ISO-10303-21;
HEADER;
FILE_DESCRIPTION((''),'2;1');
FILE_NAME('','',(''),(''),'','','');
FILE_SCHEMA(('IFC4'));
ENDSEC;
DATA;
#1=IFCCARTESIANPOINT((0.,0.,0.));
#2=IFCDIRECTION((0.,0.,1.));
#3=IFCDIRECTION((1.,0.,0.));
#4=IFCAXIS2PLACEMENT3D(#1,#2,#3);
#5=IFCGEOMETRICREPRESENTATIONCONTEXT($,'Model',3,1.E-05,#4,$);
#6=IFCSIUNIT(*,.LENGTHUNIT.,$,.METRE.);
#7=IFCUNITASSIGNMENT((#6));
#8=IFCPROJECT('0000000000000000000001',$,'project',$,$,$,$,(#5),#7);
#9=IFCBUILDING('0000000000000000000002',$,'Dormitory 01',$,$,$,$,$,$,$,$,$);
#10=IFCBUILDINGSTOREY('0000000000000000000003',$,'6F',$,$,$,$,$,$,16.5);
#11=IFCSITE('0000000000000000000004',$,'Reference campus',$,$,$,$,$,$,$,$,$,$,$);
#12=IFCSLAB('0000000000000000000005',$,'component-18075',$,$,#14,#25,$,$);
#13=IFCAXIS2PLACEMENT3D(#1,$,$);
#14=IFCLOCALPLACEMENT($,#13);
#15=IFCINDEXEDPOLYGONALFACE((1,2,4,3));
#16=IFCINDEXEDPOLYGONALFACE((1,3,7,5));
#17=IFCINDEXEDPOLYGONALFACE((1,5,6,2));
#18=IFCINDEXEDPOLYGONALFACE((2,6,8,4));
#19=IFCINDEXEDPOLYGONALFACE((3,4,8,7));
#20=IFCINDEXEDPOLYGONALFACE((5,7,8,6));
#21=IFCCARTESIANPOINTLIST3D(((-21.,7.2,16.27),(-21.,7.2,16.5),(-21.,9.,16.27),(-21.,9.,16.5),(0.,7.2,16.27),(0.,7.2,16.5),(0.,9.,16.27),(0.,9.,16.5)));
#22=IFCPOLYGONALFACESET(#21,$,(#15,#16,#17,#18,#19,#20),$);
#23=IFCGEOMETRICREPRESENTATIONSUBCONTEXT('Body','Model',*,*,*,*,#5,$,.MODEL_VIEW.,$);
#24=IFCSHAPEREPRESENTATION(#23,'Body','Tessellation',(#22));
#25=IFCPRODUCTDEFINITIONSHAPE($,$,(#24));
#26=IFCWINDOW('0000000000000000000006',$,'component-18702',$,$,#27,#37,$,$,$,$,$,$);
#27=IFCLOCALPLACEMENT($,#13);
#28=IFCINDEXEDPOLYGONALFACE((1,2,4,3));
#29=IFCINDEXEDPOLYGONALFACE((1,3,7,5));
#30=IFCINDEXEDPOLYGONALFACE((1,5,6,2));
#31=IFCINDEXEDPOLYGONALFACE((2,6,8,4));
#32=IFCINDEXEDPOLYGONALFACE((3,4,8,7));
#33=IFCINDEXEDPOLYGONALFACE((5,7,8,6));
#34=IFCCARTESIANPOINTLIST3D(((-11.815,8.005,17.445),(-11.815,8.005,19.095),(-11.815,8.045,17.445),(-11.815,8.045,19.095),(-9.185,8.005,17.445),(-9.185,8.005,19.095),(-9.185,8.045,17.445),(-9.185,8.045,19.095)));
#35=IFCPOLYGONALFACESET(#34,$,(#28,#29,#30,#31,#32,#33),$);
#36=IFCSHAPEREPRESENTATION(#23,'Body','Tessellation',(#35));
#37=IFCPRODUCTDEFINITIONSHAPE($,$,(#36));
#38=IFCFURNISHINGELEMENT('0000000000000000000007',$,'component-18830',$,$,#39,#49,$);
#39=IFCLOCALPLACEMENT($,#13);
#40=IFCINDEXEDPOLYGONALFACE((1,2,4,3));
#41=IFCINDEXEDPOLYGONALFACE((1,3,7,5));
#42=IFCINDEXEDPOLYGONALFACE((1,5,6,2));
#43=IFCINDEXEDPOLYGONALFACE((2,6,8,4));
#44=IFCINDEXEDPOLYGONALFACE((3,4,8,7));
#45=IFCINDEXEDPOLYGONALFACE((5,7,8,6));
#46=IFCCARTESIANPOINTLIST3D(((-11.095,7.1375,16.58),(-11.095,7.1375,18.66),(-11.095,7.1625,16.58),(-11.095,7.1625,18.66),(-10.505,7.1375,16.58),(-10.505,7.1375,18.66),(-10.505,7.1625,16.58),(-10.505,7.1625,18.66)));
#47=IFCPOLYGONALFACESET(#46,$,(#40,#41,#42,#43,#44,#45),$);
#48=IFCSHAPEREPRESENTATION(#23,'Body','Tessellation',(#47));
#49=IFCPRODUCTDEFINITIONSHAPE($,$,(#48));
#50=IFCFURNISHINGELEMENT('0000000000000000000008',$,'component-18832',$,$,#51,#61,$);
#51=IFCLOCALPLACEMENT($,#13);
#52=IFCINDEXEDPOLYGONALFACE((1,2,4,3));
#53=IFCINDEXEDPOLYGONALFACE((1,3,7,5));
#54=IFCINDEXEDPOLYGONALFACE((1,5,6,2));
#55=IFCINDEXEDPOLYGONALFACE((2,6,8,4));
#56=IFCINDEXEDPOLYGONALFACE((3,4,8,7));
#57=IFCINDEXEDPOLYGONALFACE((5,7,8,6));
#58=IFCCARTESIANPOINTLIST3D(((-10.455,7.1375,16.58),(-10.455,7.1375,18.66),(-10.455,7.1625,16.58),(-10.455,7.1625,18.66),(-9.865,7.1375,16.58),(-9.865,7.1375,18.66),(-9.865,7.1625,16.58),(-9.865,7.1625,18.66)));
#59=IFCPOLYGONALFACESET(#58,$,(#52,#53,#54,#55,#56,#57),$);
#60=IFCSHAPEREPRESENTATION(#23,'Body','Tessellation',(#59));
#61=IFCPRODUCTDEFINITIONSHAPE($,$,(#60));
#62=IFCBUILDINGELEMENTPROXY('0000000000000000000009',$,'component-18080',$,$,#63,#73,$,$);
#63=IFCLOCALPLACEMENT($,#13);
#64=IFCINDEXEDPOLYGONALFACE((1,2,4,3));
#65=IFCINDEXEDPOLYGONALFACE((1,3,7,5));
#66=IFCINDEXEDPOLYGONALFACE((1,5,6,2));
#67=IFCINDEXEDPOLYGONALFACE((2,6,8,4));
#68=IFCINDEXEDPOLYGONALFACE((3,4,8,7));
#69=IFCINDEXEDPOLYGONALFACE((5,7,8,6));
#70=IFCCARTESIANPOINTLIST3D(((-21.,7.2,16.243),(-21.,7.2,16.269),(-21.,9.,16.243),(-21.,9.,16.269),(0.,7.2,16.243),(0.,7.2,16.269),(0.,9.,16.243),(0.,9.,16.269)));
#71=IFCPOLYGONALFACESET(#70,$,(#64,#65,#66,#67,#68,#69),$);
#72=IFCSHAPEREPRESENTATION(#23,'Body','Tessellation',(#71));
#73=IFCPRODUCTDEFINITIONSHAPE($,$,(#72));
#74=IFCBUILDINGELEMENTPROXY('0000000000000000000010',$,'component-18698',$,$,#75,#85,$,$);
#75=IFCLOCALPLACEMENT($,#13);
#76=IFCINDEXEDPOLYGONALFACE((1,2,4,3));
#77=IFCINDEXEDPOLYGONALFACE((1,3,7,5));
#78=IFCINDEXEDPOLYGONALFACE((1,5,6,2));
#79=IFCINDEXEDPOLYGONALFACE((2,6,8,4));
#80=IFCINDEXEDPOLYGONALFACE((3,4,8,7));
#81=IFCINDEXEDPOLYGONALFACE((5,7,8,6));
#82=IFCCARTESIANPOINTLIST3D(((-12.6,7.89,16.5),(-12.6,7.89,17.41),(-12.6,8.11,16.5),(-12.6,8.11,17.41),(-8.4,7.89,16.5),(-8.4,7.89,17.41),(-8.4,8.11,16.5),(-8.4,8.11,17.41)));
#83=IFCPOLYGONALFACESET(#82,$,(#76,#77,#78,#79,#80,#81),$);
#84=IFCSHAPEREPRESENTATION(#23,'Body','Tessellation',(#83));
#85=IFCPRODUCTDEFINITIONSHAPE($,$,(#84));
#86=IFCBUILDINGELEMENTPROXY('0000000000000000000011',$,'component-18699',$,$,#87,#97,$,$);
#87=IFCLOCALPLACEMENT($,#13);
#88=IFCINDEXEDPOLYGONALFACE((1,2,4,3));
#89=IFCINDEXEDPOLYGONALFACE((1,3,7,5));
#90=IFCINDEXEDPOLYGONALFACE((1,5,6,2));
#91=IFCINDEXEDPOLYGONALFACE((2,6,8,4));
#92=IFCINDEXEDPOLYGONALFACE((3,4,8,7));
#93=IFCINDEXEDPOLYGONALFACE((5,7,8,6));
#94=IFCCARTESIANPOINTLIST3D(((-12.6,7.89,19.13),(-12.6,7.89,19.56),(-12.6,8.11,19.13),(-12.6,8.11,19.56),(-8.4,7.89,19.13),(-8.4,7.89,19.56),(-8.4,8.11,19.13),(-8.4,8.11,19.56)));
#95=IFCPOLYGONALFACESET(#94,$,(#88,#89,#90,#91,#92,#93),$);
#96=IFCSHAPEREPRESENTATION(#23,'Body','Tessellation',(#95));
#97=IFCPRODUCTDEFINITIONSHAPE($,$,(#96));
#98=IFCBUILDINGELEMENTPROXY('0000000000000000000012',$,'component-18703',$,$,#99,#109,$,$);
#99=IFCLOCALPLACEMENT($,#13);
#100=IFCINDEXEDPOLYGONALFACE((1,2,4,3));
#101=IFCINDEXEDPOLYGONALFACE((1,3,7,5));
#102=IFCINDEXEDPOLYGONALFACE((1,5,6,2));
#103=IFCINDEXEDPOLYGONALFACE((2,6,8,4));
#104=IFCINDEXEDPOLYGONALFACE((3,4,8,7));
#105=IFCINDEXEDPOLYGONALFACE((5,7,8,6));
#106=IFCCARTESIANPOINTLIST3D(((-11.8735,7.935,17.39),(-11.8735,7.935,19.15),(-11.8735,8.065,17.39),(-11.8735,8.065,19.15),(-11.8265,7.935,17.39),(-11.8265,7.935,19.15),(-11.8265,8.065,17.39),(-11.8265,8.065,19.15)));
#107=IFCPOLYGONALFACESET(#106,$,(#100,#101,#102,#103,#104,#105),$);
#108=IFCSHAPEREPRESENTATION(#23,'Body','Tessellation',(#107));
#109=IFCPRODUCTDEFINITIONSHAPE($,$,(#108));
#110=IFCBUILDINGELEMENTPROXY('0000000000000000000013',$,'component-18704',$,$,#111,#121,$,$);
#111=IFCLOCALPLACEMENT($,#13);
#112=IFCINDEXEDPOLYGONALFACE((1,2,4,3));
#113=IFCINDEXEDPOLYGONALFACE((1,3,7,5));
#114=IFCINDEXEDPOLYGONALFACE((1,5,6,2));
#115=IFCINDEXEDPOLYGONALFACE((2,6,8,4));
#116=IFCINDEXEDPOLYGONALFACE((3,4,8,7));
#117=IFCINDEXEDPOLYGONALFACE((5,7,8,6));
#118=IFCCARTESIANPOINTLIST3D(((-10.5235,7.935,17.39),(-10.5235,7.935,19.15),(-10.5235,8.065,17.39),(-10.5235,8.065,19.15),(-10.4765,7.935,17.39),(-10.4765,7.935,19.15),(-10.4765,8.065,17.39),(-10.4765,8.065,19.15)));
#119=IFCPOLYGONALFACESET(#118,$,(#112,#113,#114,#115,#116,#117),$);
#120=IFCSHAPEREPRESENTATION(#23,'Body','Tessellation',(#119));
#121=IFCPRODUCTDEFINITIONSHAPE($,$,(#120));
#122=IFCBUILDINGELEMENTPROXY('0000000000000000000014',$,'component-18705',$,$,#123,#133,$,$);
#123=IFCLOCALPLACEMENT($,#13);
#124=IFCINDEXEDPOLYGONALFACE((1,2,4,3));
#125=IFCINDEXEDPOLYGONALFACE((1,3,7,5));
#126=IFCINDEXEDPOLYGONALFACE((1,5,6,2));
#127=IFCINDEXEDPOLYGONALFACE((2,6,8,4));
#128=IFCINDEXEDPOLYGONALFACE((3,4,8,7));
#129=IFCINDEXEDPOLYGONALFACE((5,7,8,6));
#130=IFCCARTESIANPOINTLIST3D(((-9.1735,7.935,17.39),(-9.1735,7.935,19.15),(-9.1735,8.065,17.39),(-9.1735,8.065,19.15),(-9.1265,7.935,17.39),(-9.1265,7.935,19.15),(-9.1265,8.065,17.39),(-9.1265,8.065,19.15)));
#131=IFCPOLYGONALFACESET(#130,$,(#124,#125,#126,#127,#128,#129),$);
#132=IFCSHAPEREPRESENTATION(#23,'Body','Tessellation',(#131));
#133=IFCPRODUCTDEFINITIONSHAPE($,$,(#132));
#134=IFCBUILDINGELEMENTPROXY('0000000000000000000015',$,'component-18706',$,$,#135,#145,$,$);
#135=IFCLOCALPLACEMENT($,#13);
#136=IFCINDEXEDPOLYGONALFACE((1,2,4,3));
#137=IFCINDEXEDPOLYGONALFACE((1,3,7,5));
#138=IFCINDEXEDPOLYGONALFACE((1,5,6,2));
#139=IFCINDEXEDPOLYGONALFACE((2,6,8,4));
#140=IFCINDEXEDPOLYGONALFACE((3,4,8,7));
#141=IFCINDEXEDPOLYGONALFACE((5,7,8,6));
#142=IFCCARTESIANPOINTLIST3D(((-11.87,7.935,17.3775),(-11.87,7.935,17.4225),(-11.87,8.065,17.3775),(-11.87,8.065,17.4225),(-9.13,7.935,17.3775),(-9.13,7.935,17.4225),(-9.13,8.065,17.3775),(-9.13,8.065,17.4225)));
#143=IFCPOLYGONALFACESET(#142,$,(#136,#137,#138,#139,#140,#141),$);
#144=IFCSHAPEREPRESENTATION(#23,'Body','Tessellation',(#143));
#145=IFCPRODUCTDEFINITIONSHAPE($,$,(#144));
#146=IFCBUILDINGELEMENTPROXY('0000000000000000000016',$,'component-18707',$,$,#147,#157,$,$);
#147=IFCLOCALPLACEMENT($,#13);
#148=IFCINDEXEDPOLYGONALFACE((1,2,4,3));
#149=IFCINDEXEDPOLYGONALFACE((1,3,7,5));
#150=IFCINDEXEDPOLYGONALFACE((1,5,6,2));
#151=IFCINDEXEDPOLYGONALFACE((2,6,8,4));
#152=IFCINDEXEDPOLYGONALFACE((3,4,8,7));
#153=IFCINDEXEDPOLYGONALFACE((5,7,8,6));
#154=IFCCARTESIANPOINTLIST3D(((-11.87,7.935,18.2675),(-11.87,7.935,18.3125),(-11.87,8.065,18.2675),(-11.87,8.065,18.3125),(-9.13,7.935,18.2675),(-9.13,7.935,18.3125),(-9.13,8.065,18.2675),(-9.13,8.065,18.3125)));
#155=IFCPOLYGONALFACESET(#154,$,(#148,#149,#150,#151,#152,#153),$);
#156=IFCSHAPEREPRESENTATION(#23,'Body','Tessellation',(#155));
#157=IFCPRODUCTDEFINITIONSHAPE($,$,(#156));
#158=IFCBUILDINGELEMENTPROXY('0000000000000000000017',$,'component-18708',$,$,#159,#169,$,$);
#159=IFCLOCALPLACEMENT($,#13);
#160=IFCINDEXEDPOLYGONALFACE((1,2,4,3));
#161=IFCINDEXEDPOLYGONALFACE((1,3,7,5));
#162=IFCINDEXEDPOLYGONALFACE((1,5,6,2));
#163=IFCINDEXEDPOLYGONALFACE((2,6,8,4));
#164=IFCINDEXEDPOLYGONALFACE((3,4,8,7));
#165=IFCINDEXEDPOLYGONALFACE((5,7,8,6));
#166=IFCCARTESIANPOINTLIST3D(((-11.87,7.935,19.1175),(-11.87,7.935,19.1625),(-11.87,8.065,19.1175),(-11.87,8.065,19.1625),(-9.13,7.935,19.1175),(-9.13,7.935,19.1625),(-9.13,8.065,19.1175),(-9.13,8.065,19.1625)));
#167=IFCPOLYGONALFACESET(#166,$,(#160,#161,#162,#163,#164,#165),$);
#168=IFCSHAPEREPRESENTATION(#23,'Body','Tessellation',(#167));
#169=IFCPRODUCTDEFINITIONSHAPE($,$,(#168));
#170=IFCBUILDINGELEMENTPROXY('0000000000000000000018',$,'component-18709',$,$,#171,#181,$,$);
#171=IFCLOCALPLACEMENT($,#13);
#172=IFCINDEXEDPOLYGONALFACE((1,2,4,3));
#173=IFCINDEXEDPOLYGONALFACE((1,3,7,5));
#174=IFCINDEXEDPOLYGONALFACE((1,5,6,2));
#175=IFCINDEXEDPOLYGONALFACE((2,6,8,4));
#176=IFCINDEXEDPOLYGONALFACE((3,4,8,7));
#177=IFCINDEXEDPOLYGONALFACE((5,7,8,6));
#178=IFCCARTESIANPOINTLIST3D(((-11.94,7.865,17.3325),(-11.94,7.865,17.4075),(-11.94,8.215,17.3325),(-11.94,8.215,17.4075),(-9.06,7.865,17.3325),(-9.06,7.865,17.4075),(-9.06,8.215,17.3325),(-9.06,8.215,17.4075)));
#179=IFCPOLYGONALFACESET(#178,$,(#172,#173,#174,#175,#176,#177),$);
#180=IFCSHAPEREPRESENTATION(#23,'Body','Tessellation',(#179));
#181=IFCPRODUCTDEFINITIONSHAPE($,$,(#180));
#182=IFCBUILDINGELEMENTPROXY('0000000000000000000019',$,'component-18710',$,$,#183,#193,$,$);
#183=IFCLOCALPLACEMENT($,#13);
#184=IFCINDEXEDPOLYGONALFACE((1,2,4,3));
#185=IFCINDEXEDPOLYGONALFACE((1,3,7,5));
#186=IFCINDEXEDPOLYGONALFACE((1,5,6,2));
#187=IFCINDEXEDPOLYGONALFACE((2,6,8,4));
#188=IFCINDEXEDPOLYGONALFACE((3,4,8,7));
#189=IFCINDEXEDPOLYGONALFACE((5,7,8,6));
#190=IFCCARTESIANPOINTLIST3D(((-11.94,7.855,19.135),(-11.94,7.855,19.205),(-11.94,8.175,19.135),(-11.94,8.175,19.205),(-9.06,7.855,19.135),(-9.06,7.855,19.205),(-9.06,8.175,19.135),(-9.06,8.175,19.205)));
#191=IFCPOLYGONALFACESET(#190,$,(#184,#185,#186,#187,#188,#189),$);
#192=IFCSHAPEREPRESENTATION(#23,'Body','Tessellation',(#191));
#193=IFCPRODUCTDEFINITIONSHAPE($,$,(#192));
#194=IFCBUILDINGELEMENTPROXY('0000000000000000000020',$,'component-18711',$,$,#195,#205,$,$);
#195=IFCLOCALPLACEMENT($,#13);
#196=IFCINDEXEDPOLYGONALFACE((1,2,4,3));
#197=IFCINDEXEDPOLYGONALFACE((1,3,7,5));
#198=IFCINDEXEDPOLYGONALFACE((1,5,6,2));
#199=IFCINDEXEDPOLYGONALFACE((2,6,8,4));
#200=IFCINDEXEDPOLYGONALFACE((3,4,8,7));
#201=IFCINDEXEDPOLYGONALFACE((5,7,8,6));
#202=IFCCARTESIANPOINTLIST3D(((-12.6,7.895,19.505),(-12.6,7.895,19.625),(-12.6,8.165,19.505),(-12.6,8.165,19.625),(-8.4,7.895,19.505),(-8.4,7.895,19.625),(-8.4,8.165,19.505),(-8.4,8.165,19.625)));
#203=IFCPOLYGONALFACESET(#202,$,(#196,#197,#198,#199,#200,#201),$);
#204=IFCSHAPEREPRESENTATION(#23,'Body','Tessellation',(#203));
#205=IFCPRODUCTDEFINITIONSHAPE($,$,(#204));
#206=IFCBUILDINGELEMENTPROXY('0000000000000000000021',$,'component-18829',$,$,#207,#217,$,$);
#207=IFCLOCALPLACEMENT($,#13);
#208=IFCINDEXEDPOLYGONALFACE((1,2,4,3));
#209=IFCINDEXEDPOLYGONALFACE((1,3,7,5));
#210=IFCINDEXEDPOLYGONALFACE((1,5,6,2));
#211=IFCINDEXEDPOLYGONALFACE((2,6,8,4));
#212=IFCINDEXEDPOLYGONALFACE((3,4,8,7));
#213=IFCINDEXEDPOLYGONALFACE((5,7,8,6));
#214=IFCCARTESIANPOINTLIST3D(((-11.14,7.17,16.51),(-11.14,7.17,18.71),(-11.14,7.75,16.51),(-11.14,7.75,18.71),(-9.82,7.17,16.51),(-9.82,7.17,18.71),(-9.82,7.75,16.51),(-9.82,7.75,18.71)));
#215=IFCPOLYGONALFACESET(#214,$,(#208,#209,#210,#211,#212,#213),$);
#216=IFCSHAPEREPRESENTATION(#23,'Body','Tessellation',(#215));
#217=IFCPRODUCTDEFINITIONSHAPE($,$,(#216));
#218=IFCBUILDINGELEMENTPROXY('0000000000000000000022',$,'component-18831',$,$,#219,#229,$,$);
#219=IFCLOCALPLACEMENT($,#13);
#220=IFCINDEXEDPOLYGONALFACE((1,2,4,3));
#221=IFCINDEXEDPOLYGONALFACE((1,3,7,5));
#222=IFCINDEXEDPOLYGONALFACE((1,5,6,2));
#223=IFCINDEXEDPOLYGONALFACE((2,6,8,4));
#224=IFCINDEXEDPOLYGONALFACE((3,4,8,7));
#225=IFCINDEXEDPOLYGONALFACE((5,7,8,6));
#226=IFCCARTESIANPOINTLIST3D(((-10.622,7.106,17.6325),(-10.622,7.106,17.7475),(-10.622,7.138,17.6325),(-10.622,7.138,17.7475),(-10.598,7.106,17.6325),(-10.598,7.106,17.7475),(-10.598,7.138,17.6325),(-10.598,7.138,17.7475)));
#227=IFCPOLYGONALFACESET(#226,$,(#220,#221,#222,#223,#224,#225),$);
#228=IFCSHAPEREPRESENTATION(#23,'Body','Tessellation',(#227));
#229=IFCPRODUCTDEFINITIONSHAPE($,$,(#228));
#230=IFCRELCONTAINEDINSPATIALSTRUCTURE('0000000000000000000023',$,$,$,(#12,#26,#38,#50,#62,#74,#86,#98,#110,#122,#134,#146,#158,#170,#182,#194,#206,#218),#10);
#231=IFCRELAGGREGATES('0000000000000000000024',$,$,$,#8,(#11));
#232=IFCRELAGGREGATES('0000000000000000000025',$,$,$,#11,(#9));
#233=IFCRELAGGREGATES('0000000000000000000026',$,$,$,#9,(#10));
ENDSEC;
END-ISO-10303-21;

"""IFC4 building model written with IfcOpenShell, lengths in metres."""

from ifc_helpers import new_model, si_unit, frame, origin, origin_with_axes, origin_2d, place, context, subcontext, project, spatial, rectangle, extrude, element, save


model = new_model("IFC4")

# Units and contexts
model_context = context("Model", 3, precision=1e-05, world=origin_with_axes())
body_context = subcontext(model_context, "Body", "Model", "MODEL_VIEW")
ifc_project = project(units=[si_unit("LENGTHUNIT", "METRE")], contexts=[model_context])

# Site, building, storey
site = spatial("IfcSite", under=ifc_project, Name="Reference campus")
building = spatial("IfcBuilding", under=site, Name="Dormitory 01")
storey = spatial("IfcBuildingStorey", under=building, Name="6F", Elevation=16.5)

# Slab
slab_placement = place(None, frame((-10.5, 8.1, 16.27), z_axis=(0.0, 0.0, 1.0), x_axis=(1.0, 0.0, 0.0)))
element("IfcSlab", 1, at=slab_placement, inside=storey, Name="component-18075", context=body_context, shape_type="SweptSolid", body=[
    extrude(rectangle(XDim=21.0, YDim=1.8, at=origin_2d()), origin(), (0.0, 0.0, 1.0), 0.23),
])

# Window
window_placement = place(None, frame((-10.5, 8.025, 17.445), z_axis=(0.0, 0.0, 1.0), x_axis=(1.0, 0.0, 0.0)))
element("IfcWindow", 2, at=window_placement, inside=storey, Name="component-18702", context=body_context, shape_type="SweptSolid", body=[
    extrude(rectangle(XDim=2.63, YDim=0.04, at=origin_2d()), origin(), (0.0, 0.0, 1.0), 1.65),
])

# Furnishing elements
for number, where, z_axis, x_axis, name in (
    (3, (-10.8, 7.15, 16.58), (0.0, 0.0, 1.0), (1.0, 0.0, 0.0), "component-18830"),
    (4, (-10.16, 7.15, 16.58), (0.0, 0.0, 1.0), (1.0, 0.0, 0.0), "component-18832"),
):
    element("IfcFurnishingElement", number, at=place(None, frame(where, z_axis=z_axis, x_axis=x_axis)), inside=storey, Name=name, context=body_context, shape_type="SweptSolid", body=[
        extrude(rectangle(XDim=0.59, YDim=0.025, at=origin_2d()), origin(), (0.0, 0.0, 1.0), 2.08),
    ])

# Building element proxies
proxy_1_placement = place(None, frame((-10.5, 8.1, 16.243), z_axis=(0.0, 0.0, 1.0), x_axis=(1.0, 0.0, 0.0)))
element("IfcBuildingElementProxy", 5, at=proxy_1_placement, inside=storey, Name="component-18080", context=body_context, shape_type="SweptSolid", body=[
    extrude(rectangle(XDim=21.0, YDim=1.8, at=origin_2d()), origin(), (0.0, 0.0, 1.0), 0.026),
])
proxy_2_placement = place(None, frame((-10.5, 8.0, 16.5), z_axis=(0.0, 0.0, 1.0), x_axis=(1.0, 0.0, 0.0)))
element("IfcBuildingElementProxy", 6, at=proxy_2_placement, inside=storey, Name="component-18698", context=body_context, shape_type="SweptSolid", body=[
    extrude(rectangle(XDim=4.2, YDim=0.22, at=origin_2d()), origin(), (0.0, 0.0, 1.0), 0.91),
])
proxy_3_placement = place(None, frame((-10.5, 8.0, 19.13), z_axis=(0.0, 0.0, 1.0), x_axis=(1.0, 0.0, 0.0)))
element("IfcBuildingElementProxy", 7, at=proxy_3_placement, inside=storey, Name="component-18699", context=body_context, shape_type="SweptSolid", body=[
    extrude(rectangle(XDim=4.2, YDim=0.22, at=origin_2d()), origin(), (0.0, 0.0, 1.0), 0.43),
])
for number, where, z_axis, x_axis, name in (
    (8, (-11.85, 8.0, 17.39), (0.0, 0.0, 1.0), (1.0, 0.0, 0.0), "component-18703"),
    (9, (-10.5, 8.0, 17.39), (0.0, 0.0, 1.0), (1.0, 0.0, 0.0), "component-18704"),
    (10, (-9.15, 8.0, 17.39), (0.0, 0.0, 1.0), (1.0, 0.0, 0.0), "component-18705"),
):
    element("IfcBuildingElementProxy", number, at=place(None, frame(where, z_axis=z_axis, x_axis=x_axis)), inside=storey, Name=name, context=body_context, shape_type="SweptSolid", body=[
        extrude(rectangle(XDim=0.047, YDim=0.13, at=origin_2d()), origin(), (0.0, 0.0, 1.0), 1.76),
    ])
for number, where, z_axis, x_axis, name in (
    (11, (-10.5, 8.0, 17.3775), (0.0, 0.0, 1.0), (1.0, 0.0, 0.0), "component-18706"),
    (12, (-10.5, 8.0, 18.2675), (0.0, 0.0, 1.0), (1.0, 0.0, 0.0), "component-18707"),
    (13, (-10.5, 8.0, 19.1175), (0.0, 0.0, 1.0), (1.0, 0.0, 0.0), "component-18708"),
):
    element("IfcBuildingElementProxy", number, at=place(None, frame(where, z_axis=z_axis, x_axis=x_axis)), inside=storey, Name=name, context=body_context, shape_type="SweptSolid", body=[
        extrude(rectangle(XDim=2.74, YDim=0.13, at=origin_2d()), origin(), (0.0, 0.0, 1.0), 0.045),
    ])
proxy_4_placement = place(None, frame((-10.5, 8.04, 17.3325), z_axis=(0.0, 0.0, 1.0), x_axis=(1.0, 0.0, 0.0)))
element("IfcBuildingElementProxy", 14, at=proxy_4_placement, inside=storey, Name="component-18709", context=body_context, shape_type="SweptSolid", body=[
    extrude(rectangle(XDim=2.88, YDim=0.35, at=origin_2d()), origin(), (0.0, 0.0, 1.0), 0.075),
])
proxy_5_placement = place(None, frame((-10.5, 8.015, 19.135), z_axis=(0.0, 0.0, 1.0), x_axis=(1.0, 0.0, 0.0)))
element("IfcBuildingElementProxy", 15, at=proxy_5_placement, inside=storey, Name="component-18710", context=body_context, shape_type="SweptSolid", body=[
    extrude(rectangle(XDim=2.88, YDim=0.32, at=origin_2d()), origin(), (0.0, 0.0, 1.0), 0.07),
])
proxy_6_placement = place(None, frame((-10.5, 8.03, 19.505), z_axis=(0.0, 0.0, 1.0), x_axis=(1.0, 0.0, 0.0)))
element("IfcBuildingElementProxy", 16, at=proxy_6_placement, inside=storey, Name="component-18711", context=body_context, shape_type="SweptSolid", body=[
    extrude(rectangle(XDim=4.2, YDim=0.27, at=origin_2d()), origin(), (0.0, 0.0, 1.0), 0.12),
])
proxy_7_placement = place(None, frame((-10.48, 7.46, 16.51), z_axis=(0.0, 0.0, 1.0), x_axis=(1.0, 0.0, 0.0)))
element("IfcBuildingElementProxy", 17, at=proxy_7_placement, inside=storey, Name="component-18829", context=body_context, shape_type="SweptSolid", body=[
    extrude(rectangle(XDim=1.32, YDim=0.58, at=origin_2d()), origin(), (0.0, 0.0, 1.0), 2.2),
])
for number, where, z_axis, x_axis, name in (
    (18, (-10.61, 7.122, 17.6325), (0.0, 0.0, 1.0), (1.0, 0.0, 0.0), "component-18831"),
):
    element("IfcBuildingElementProxy", number, at=place(None, frame(where, z_axis=z_axis, x_axis=x_axis)), inside=storey, Name=name, context=body_context, shape_type="SweptSolid", body=[
        extrude(rectangle(XDim=0.024, YDim=0.032, at=origin_2d()), origin(), (0.0, 0.0, 1.0), 0.115),
    ])

save(model, "model.ifc")
